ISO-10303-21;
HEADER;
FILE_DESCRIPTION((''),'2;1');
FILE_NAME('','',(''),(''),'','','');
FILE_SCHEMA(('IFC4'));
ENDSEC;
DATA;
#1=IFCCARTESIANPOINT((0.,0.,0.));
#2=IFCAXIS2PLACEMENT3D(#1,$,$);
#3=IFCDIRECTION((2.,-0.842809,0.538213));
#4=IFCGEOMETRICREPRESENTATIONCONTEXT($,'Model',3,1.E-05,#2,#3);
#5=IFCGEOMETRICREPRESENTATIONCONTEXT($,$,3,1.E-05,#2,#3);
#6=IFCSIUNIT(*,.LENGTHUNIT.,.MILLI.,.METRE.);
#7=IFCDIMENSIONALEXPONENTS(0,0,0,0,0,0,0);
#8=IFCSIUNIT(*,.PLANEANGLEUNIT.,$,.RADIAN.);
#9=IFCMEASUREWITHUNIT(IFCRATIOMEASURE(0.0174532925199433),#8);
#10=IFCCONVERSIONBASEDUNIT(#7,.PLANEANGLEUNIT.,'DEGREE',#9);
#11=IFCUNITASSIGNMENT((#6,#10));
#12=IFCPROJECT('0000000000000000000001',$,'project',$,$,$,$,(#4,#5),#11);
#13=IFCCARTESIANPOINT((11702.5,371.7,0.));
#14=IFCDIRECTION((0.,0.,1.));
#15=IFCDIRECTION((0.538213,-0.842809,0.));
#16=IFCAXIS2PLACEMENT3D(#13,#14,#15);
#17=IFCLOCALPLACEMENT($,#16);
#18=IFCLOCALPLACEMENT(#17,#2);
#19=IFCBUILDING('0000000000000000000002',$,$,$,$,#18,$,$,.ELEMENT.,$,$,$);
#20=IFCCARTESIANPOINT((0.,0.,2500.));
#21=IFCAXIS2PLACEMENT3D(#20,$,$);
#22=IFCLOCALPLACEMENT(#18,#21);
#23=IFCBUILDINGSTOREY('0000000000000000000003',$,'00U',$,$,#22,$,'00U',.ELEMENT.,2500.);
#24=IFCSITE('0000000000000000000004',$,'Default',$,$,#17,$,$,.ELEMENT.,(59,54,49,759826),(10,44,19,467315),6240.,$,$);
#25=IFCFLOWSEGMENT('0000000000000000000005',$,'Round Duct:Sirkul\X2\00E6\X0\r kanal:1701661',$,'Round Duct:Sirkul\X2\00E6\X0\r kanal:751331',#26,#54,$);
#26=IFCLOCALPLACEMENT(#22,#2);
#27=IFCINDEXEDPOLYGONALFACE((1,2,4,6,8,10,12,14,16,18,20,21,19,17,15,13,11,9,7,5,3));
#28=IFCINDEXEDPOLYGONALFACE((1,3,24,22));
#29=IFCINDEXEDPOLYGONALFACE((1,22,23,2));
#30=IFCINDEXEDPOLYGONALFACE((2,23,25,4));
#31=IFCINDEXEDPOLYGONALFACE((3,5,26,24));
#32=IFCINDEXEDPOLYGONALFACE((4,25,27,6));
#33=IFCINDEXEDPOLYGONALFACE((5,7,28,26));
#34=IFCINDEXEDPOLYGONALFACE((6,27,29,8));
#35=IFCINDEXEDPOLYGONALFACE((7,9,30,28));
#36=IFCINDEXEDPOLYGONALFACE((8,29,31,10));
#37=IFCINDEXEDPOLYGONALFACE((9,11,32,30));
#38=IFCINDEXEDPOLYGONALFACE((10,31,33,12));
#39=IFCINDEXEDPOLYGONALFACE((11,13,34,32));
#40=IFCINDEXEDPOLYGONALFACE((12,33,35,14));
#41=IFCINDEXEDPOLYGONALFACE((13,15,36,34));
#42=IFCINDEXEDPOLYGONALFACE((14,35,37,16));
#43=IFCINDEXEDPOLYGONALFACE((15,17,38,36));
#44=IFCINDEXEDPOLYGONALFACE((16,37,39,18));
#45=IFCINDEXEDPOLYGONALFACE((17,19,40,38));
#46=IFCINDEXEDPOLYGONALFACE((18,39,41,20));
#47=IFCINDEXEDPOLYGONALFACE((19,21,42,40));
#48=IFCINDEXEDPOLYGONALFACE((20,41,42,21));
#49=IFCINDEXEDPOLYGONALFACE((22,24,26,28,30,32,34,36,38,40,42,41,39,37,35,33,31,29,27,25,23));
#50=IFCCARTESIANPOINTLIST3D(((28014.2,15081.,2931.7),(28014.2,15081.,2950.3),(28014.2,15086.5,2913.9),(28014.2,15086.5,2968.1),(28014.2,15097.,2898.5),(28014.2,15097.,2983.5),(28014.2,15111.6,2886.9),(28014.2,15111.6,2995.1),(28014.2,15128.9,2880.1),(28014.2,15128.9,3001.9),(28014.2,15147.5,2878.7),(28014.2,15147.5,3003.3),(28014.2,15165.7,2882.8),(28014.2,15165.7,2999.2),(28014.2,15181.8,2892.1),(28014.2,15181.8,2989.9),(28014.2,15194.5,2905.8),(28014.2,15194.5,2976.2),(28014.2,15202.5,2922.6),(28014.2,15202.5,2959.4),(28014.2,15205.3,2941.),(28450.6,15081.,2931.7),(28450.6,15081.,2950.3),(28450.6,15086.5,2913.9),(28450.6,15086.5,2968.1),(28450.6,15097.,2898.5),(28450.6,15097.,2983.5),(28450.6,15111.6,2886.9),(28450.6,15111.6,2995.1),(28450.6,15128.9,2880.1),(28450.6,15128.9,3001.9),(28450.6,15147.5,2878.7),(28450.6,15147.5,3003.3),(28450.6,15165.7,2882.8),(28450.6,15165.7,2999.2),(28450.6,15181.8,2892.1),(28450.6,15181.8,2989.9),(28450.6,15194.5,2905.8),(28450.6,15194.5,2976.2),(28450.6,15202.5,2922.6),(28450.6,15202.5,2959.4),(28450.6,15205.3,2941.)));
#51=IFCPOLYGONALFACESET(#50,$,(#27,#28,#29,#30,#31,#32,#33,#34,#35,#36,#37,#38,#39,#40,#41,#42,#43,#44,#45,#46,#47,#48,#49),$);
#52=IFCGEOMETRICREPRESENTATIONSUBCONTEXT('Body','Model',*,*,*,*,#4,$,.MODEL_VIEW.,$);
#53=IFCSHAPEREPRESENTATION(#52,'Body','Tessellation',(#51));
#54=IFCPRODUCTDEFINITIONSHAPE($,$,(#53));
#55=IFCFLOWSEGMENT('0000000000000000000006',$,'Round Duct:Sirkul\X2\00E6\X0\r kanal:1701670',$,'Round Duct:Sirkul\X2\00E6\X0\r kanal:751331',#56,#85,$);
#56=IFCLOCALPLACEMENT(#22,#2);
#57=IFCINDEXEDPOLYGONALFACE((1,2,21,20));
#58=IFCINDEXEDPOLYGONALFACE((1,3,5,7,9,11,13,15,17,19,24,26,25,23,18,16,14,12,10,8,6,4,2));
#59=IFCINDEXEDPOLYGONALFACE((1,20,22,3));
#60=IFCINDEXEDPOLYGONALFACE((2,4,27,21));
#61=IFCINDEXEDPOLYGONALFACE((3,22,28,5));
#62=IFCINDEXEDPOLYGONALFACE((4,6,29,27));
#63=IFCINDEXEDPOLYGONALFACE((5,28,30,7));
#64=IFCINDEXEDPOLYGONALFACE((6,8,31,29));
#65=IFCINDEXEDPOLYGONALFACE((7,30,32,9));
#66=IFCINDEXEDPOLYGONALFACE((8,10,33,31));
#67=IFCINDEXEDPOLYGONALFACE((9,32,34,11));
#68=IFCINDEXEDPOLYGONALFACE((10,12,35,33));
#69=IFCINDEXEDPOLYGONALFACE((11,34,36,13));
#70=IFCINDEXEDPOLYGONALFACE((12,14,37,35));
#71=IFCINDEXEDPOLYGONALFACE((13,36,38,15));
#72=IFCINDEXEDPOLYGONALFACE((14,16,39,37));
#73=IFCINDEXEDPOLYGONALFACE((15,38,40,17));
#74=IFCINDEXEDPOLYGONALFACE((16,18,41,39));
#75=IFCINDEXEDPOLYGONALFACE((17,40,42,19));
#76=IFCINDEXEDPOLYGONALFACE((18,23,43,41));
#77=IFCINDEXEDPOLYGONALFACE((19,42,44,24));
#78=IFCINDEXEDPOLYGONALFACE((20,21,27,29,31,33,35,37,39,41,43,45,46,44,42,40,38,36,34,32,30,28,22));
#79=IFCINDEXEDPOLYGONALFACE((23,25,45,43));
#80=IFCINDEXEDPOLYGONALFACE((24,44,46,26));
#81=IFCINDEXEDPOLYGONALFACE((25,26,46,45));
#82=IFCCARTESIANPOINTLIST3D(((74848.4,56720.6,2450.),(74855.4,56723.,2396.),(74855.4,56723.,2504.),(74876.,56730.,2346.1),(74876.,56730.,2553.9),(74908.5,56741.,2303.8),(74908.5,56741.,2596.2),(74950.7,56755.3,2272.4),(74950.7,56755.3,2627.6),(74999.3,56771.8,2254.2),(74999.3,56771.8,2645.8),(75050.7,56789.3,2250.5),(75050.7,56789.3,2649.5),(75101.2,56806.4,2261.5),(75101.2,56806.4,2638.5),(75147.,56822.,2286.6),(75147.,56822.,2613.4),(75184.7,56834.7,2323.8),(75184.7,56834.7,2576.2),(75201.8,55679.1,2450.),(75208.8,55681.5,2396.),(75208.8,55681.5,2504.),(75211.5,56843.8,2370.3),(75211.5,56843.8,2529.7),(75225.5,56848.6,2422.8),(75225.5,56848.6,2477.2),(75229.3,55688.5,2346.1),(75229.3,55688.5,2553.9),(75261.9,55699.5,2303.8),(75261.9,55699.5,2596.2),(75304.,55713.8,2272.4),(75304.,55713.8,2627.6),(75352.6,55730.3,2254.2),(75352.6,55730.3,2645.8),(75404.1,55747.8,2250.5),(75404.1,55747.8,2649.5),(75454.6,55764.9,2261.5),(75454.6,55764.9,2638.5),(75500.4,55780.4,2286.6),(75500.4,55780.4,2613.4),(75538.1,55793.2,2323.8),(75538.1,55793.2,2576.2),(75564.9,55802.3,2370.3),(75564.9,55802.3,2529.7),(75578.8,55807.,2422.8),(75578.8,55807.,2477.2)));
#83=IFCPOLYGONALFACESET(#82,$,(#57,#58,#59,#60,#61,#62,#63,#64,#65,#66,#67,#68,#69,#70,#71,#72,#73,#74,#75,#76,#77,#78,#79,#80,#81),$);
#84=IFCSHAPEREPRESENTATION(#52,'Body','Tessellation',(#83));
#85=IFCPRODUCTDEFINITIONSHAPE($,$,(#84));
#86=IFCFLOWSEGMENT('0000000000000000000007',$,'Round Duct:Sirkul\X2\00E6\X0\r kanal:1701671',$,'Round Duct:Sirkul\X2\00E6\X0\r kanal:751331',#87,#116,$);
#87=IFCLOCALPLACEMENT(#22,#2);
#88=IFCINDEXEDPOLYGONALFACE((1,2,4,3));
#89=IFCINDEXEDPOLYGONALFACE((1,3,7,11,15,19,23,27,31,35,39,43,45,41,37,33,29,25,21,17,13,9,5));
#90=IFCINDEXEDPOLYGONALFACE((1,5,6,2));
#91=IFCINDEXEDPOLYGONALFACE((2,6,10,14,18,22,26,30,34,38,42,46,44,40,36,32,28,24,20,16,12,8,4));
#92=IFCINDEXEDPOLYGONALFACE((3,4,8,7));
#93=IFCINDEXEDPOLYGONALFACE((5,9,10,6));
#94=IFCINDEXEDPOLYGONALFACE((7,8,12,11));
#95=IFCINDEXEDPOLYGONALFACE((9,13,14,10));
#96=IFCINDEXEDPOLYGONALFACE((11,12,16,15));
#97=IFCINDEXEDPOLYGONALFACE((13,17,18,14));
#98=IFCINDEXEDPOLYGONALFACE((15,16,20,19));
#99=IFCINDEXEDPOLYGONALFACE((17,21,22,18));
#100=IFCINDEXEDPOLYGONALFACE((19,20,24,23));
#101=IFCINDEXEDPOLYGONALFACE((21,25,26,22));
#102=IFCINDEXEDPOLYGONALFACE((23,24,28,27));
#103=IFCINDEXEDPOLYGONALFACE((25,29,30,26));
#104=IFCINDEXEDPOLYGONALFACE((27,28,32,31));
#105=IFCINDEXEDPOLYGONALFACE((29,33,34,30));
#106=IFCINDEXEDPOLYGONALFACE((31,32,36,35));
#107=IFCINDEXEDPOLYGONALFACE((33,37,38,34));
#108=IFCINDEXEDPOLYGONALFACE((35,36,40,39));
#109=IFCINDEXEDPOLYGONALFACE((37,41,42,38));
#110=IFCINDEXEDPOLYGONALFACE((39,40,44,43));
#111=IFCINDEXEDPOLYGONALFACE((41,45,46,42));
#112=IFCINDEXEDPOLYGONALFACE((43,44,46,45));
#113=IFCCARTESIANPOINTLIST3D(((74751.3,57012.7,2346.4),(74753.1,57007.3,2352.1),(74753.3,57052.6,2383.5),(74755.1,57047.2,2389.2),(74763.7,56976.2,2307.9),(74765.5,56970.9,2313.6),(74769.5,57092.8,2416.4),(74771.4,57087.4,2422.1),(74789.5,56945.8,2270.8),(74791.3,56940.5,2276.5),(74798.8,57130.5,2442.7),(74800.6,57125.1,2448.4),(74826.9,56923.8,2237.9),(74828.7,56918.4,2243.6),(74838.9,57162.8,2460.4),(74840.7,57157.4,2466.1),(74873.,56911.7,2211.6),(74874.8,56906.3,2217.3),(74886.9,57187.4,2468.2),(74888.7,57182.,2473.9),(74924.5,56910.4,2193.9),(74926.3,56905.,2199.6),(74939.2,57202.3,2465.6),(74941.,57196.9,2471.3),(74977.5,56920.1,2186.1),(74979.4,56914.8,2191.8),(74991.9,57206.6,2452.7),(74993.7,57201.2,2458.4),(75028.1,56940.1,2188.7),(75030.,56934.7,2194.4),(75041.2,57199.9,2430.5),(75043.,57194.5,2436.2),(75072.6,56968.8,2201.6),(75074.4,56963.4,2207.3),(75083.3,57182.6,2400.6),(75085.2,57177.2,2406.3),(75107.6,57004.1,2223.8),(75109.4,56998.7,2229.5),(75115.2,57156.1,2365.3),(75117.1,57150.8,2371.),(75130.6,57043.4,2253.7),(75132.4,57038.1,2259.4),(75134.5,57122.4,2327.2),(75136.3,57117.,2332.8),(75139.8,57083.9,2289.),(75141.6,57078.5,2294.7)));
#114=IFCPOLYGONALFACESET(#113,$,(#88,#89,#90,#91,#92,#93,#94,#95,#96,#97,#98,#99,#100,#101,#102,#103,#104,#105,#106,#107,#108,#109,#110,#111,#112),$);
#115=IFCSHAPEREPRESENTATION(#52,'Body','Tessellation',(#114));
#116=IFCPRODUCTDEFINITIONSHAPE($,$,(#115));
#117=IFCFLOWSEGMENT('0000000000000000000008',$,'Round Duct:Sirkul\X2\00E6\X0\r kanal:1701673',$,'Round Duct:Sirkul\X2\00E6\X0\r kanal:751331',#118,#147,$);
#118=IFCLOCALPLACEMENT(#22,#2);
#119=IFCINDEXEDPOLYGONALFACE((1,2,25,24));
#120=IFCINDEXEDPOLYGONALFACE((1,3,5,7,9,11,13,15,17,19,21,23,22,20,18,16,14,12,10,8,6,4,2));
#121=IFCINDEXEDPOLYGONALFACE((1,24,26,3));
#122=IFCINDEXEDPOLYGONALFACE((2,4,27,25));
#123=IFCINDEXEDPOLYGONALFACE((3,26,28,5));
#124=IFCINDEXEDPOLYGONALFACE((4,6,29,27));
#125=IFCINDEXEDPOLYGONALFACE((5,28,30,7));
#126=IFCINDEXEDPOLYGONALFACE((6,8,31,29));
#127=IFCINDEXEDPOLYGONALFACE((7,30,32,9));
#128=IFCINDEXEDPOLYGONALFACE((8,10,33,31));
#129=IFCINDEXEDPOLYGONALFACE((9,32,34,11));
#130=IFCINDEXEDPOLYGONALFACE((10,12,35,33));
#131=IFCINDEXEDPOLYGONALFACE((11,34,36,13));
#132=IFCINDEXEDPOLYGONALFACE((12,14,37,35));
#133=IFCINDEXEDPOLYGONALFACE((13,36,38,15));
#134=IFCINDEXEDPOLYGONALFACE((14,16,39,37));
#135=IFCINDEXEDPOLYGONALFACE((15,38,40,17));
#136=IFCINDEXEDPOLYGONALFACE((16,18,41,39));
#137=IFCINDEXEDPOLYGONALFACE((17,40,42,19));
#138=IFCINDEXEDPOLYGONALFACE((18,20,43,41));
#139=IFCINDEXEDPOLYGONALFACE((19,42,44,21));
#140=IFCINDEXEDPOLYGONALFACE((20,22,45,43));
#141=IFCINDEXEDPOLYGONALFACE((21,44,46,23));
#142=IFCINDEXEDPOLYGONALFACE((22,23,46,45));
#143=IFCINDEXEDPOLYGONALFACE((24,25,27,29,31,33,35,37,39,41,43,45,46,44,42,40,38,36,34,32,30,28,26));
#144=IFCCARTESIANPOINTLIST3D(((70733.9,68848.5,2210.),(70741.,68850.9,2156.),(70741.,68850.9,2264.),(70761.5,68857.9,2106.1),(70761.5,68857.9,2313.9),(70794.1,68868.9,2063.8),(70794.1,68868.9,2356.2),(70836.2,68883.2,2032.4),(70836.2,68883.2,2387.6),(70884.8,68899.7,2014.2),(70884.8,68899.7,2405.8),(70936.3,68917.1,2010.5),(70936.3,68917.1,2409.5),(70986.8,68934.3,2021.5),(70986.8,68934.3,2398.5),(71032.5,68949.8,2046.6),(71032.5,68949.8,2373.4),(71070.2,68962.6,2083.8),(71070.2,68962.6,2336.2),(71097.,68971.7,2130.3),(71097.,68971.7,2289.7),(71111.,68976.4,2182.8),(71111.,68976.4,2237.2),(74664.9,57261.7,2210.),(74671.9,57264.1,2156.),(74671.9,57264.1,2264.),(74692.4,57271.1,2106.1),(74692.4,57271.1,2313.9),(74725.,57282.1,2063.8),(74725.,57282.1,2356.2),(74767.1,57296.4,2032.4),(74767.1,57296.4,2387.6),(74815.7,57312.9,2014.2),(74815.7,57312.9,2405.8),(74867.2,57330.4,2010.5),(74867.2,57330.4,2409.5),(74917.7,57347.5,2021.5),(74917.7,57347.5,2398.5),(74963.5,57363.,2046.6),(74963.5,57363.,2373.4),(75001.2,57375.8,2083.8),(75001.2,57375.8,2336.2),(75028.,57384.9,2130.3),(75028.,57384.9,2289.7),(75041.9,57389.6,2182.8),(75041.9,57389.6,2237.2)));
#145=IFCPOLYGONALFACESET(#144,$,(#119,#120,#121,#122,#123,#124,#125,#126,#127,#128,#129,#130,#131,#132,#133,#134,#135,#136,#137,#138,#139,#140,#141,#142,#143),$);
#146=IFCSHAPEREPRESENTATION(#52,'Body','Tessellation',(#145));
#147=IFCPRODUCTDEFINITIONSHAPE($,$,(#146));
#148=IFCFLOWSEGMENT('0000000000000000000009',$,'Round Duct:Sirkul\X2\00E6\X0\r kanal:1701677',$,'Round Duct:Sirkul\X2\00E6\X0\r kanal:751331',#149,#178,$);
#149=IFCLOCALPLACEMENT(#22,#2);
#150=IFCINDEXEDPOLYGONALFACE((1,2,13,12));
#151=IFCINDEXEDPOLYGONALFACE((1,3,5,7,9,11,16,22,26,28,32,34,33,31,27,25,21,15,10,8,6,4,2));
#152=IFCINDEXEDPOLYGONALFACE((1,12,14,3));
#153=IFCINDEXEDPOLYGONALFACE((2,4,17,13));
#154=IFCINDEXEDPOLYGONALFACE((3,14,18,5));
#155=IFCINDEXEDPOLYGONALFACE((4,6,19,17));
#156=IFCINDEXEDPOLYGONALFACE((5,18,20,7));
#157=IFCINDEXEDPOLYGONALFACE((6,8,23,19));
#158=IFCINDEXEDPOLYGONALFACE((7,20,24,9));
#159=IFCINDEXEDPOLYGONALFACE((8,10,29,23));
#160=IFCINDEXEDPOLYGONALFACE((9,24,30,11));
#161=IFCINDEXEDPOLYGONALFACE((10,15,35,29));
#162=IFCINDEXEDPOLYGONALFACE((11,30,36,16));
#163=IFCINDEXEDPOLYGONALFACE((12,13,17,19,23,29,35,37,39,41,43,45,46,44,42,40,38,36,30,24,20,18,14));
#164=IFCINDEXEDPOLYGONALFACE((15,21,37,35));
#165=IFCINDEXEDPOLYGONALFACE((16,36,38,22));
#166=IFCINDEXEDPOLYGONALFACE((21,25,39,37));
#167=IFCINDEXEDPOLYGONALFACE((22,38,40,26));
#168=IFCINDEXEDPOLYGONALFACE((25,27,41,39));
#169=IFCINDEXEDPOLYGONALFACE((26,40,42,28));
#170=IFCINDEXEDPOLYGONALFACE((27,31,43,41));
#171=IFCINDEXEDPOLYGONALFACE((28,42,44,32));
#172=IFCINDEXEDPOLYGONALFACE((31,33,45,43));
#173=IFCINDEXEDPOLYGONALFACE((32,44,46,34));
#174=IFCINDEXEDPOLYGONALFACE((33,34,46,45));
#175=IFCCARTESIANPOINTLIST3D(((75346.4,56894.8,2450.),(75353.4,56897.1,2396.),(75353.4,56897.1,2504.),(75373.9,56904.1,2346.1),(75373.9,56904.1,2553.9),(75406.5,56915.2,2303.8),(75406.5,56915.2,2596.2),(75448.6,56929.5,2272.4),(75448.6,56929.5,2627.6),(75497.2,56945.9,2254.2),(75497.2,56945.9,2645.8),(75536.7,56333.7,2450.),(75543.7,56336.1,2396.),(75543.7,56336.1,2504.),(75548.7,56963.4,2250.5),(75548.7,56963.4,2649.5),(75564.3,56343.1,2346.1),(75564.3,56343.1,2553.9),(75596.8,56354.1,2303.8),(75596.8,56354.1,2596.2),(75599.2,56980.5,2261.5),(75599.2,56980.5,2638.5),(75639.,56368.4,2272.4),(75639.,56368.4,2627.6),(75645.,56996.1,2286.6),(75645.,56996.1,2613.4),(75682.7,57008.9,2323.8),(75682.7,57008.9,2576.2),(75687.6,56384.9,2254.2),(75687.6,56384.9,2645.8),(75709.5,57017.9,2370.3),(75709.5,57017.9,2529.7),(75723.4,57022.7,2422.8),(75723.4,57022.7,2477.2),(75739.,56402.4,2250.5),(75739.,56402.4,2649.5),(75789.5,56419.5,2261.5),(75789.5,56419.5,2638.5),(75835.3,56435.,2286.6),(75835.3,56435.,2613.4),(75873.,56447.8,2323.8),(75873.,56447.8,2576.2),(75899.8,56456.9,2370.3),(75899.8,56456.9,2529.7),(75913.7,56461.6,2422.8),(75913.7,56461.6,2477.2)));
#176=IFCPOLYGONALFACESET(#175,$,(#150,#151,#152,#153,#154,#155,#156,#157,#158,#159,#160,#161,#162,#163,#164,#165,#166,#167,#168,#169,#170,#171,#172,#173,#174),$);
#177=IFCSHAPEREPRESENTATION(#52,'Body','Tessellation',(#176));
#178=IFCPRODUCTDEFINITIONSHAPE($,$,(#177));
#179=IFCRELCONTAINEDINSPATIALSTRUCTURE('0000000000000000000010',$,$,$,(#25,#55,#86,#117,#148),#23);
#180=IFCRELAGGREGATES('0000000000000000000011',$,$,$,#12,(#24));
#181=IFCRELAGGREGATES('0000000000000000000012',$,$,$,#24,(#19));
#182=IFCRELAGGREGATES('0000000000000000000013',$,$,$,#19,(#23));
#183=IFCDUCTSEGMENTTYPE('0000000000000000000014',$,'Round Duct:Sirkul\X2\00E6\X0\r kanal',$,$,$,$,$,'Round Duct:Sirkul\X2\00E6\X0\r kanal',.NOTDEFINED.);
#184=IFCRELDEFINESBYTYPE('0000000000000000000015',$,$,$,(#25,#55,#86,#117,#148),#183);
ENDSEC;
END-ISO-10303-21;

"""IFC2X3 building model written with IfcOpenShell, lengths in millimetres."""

from ifc_helpers import new_model, entity, si_unit, converted_unit, direction, frame, frame_2d, origin, origin_2d_with_axis, place, context, subcontext, project, spatial, circle, extrude, type_object, element, save


model = new_model("IFC2X3")

# Units and contexts
model_context = context("Model", 3, precision=1e-05, world=origin(), true_north=direction((2.0, -0.842809, 0.538213)))
context_of_model = context(None, 3, precision=1e-05, world=origin(), true_north=direction((2.0, -0.842809, 0.538213)))
body_context = subcontext(model_context, "Body", "Model", "MODEL_VIEW")
ifc_project = project(units=[si_unit("LENGTHUNIT", "METRE", prefix="MILLI"), converted_unit("PLANEANGLEUNIT", "DEGREE", entity("IfcRatioMeasure", 0.0174532925199433), si_unit("PLANEANGLEUNIT", "RADIAN"), dimensions=[0, 0, 0, 0, 0, 0, 0])], contexts=[model_context, context_of_model])

# Site, building, storey
site_placement = place(None, frame((11702.5, 371.7, 0.0), z_axis=(0.0, 0.0, 1.0), x_axis=(0.538213, -0.842809, 0.0)))
site = spatial("IfcSite", under=ifc_project, at=site_placement, Name="Default", CompositionType="ELEMENT", RefLatitude=(59, 54, 49, 759826), RefLongitude=(10, 44, 19, 467315), RefElevation=6240.0)
building_placement = place(site_placement, origin())
building = spatial("IfcBuilding", under=site, at=building_placement, CompositionType="ELEMENT")
storey_placement = place(building_placement, frame((0.0, 0.0, 2500.0)))
storey = spatial("IfcBuildingStorey", under=building, at=storey_placement, Name="00U", LongName="00U", CompositionType="ELEMENT", Elevation=2500.0)

# Flow segments
duct_segment_type = type_object("IfcDuctSegmentType", Name="Round Duct:Sirkulær kanal", ElementType="Round Duct:Sirkulær kanal", PredefinedType="NOTDEFINED")
flow_segment_1_placement = place(storey_placement, origin())
element("IfcFlowSegment", 1, at=flow_segment_1_placement, inside=storey, type_object=duct_segment_type, Name="Round Duct:Sirkulær kanal:1701661", ObjectType="Round Duct:Sirkulær kanal:751331", context=body_context, shape_type="SweptSolid", body=[
    extrude(circle(Radius=62.5, at=frame_2d((0.0, 0.0), x_axis=(1.0, 0.0))), frame((28014.2, 15142.8, 2941.0), z_axis=(1.0, 0.0, 0.0), x_axis=(0.0, 1.0, 0.0)), (0.0, 0.0, 1.0), 436.4),
])
flow_segment_2_placement = place(storey_placement, origin())
element("IfcFlowSegment", 2, at=flow_segment_2_placement, inside=storey, type_object=duct_segment_type, Name="Round Duct:Sirkulær kanal:1701670", ObjectType="Round Duct:Sirkulær kanal:751331", context=body_context, shape_type="SweptSolid", body=[
    extrude(circle(Radius=200.0, at=origin_2d_with_axis()), frame((75037.8, 56784.9, 2450.0), z_axis=(0.321274, -0.946986, 0.0), x_axis=(-0.946986, -0.321274, 0.0)), (0.0, 0.0, 1.0), 1099.8),
])
flow_segment_3_placement = place(storey_placement, origin())
element("IfcFlowSegment", 3, at=flow_segment_3_placement, inside=storey, type_object=duct_segment_type, Name="Round Duct:Sirkulær kanal:1701671", ObjectType="Round Duct:Sirkulær kanal:751331", context=body_context, shape_type="SweptSolid", body=[
    extrude(circle(Radius=200.0, at=frame_2d((0.0, 0.0), x_axis=(1.0, 0.0))), frame((74945.1, 57058.1, 2327.2), z_axis=(0.227175, -0.66962, 0.707107), x_axis=(0.946986, 0.321274, 0.0)), (0.0, 0.0, 1.0), 8.0),
])
flow_segment_4_placement = place(storey_placement, origin())
element("IfcFlowSegment", 4, at=flow_segment_4_placement, inside=storey, type_object=duct_segment_type, Name="Round Duct:Sirkulær kanal:1701673", ObjectType="Round Duct:Sirkulær kanal:751331", context=body_context, shape_type="SweptSolid", body=[
    extrude(circle(Radius=200.0, at=origin_2d_with_axis()), frame((70923.3, 68912.8, 2210.0), z_axis=(0.321274, -0.946986, 0.0), x_axis=(-0.946986, -0.321274, 0.0)), (0.0, 0.0, 1.0), 12235.4),
])
flow_segment_5_placement = place(storey_placement, origin())
element("IfcFlowSegment", 5, at=flow_segment_5_placement, inside=storey, type_object=duct_segment_type, Name="Round Duct:Sirkulær kanal:1701677", ObjectType="Round Duct:Sirkulær kanal:751331", context=body_context, shape_type="SweptSolid", body=[
    extrude(circle(Radius=200.0, at=frame_2d((0.0, 0.0), x_axis=(1.0, 0.0))), frame((75726.1, 56398.0, 2450.0), z_axis=(-0.321274, 0.946986, 0.0), x_axis=(-0.946986, -0.321274, 0.0)), (0.0, 0.0, 1.0), 592.4),
])

save(model, "model.ifc")
